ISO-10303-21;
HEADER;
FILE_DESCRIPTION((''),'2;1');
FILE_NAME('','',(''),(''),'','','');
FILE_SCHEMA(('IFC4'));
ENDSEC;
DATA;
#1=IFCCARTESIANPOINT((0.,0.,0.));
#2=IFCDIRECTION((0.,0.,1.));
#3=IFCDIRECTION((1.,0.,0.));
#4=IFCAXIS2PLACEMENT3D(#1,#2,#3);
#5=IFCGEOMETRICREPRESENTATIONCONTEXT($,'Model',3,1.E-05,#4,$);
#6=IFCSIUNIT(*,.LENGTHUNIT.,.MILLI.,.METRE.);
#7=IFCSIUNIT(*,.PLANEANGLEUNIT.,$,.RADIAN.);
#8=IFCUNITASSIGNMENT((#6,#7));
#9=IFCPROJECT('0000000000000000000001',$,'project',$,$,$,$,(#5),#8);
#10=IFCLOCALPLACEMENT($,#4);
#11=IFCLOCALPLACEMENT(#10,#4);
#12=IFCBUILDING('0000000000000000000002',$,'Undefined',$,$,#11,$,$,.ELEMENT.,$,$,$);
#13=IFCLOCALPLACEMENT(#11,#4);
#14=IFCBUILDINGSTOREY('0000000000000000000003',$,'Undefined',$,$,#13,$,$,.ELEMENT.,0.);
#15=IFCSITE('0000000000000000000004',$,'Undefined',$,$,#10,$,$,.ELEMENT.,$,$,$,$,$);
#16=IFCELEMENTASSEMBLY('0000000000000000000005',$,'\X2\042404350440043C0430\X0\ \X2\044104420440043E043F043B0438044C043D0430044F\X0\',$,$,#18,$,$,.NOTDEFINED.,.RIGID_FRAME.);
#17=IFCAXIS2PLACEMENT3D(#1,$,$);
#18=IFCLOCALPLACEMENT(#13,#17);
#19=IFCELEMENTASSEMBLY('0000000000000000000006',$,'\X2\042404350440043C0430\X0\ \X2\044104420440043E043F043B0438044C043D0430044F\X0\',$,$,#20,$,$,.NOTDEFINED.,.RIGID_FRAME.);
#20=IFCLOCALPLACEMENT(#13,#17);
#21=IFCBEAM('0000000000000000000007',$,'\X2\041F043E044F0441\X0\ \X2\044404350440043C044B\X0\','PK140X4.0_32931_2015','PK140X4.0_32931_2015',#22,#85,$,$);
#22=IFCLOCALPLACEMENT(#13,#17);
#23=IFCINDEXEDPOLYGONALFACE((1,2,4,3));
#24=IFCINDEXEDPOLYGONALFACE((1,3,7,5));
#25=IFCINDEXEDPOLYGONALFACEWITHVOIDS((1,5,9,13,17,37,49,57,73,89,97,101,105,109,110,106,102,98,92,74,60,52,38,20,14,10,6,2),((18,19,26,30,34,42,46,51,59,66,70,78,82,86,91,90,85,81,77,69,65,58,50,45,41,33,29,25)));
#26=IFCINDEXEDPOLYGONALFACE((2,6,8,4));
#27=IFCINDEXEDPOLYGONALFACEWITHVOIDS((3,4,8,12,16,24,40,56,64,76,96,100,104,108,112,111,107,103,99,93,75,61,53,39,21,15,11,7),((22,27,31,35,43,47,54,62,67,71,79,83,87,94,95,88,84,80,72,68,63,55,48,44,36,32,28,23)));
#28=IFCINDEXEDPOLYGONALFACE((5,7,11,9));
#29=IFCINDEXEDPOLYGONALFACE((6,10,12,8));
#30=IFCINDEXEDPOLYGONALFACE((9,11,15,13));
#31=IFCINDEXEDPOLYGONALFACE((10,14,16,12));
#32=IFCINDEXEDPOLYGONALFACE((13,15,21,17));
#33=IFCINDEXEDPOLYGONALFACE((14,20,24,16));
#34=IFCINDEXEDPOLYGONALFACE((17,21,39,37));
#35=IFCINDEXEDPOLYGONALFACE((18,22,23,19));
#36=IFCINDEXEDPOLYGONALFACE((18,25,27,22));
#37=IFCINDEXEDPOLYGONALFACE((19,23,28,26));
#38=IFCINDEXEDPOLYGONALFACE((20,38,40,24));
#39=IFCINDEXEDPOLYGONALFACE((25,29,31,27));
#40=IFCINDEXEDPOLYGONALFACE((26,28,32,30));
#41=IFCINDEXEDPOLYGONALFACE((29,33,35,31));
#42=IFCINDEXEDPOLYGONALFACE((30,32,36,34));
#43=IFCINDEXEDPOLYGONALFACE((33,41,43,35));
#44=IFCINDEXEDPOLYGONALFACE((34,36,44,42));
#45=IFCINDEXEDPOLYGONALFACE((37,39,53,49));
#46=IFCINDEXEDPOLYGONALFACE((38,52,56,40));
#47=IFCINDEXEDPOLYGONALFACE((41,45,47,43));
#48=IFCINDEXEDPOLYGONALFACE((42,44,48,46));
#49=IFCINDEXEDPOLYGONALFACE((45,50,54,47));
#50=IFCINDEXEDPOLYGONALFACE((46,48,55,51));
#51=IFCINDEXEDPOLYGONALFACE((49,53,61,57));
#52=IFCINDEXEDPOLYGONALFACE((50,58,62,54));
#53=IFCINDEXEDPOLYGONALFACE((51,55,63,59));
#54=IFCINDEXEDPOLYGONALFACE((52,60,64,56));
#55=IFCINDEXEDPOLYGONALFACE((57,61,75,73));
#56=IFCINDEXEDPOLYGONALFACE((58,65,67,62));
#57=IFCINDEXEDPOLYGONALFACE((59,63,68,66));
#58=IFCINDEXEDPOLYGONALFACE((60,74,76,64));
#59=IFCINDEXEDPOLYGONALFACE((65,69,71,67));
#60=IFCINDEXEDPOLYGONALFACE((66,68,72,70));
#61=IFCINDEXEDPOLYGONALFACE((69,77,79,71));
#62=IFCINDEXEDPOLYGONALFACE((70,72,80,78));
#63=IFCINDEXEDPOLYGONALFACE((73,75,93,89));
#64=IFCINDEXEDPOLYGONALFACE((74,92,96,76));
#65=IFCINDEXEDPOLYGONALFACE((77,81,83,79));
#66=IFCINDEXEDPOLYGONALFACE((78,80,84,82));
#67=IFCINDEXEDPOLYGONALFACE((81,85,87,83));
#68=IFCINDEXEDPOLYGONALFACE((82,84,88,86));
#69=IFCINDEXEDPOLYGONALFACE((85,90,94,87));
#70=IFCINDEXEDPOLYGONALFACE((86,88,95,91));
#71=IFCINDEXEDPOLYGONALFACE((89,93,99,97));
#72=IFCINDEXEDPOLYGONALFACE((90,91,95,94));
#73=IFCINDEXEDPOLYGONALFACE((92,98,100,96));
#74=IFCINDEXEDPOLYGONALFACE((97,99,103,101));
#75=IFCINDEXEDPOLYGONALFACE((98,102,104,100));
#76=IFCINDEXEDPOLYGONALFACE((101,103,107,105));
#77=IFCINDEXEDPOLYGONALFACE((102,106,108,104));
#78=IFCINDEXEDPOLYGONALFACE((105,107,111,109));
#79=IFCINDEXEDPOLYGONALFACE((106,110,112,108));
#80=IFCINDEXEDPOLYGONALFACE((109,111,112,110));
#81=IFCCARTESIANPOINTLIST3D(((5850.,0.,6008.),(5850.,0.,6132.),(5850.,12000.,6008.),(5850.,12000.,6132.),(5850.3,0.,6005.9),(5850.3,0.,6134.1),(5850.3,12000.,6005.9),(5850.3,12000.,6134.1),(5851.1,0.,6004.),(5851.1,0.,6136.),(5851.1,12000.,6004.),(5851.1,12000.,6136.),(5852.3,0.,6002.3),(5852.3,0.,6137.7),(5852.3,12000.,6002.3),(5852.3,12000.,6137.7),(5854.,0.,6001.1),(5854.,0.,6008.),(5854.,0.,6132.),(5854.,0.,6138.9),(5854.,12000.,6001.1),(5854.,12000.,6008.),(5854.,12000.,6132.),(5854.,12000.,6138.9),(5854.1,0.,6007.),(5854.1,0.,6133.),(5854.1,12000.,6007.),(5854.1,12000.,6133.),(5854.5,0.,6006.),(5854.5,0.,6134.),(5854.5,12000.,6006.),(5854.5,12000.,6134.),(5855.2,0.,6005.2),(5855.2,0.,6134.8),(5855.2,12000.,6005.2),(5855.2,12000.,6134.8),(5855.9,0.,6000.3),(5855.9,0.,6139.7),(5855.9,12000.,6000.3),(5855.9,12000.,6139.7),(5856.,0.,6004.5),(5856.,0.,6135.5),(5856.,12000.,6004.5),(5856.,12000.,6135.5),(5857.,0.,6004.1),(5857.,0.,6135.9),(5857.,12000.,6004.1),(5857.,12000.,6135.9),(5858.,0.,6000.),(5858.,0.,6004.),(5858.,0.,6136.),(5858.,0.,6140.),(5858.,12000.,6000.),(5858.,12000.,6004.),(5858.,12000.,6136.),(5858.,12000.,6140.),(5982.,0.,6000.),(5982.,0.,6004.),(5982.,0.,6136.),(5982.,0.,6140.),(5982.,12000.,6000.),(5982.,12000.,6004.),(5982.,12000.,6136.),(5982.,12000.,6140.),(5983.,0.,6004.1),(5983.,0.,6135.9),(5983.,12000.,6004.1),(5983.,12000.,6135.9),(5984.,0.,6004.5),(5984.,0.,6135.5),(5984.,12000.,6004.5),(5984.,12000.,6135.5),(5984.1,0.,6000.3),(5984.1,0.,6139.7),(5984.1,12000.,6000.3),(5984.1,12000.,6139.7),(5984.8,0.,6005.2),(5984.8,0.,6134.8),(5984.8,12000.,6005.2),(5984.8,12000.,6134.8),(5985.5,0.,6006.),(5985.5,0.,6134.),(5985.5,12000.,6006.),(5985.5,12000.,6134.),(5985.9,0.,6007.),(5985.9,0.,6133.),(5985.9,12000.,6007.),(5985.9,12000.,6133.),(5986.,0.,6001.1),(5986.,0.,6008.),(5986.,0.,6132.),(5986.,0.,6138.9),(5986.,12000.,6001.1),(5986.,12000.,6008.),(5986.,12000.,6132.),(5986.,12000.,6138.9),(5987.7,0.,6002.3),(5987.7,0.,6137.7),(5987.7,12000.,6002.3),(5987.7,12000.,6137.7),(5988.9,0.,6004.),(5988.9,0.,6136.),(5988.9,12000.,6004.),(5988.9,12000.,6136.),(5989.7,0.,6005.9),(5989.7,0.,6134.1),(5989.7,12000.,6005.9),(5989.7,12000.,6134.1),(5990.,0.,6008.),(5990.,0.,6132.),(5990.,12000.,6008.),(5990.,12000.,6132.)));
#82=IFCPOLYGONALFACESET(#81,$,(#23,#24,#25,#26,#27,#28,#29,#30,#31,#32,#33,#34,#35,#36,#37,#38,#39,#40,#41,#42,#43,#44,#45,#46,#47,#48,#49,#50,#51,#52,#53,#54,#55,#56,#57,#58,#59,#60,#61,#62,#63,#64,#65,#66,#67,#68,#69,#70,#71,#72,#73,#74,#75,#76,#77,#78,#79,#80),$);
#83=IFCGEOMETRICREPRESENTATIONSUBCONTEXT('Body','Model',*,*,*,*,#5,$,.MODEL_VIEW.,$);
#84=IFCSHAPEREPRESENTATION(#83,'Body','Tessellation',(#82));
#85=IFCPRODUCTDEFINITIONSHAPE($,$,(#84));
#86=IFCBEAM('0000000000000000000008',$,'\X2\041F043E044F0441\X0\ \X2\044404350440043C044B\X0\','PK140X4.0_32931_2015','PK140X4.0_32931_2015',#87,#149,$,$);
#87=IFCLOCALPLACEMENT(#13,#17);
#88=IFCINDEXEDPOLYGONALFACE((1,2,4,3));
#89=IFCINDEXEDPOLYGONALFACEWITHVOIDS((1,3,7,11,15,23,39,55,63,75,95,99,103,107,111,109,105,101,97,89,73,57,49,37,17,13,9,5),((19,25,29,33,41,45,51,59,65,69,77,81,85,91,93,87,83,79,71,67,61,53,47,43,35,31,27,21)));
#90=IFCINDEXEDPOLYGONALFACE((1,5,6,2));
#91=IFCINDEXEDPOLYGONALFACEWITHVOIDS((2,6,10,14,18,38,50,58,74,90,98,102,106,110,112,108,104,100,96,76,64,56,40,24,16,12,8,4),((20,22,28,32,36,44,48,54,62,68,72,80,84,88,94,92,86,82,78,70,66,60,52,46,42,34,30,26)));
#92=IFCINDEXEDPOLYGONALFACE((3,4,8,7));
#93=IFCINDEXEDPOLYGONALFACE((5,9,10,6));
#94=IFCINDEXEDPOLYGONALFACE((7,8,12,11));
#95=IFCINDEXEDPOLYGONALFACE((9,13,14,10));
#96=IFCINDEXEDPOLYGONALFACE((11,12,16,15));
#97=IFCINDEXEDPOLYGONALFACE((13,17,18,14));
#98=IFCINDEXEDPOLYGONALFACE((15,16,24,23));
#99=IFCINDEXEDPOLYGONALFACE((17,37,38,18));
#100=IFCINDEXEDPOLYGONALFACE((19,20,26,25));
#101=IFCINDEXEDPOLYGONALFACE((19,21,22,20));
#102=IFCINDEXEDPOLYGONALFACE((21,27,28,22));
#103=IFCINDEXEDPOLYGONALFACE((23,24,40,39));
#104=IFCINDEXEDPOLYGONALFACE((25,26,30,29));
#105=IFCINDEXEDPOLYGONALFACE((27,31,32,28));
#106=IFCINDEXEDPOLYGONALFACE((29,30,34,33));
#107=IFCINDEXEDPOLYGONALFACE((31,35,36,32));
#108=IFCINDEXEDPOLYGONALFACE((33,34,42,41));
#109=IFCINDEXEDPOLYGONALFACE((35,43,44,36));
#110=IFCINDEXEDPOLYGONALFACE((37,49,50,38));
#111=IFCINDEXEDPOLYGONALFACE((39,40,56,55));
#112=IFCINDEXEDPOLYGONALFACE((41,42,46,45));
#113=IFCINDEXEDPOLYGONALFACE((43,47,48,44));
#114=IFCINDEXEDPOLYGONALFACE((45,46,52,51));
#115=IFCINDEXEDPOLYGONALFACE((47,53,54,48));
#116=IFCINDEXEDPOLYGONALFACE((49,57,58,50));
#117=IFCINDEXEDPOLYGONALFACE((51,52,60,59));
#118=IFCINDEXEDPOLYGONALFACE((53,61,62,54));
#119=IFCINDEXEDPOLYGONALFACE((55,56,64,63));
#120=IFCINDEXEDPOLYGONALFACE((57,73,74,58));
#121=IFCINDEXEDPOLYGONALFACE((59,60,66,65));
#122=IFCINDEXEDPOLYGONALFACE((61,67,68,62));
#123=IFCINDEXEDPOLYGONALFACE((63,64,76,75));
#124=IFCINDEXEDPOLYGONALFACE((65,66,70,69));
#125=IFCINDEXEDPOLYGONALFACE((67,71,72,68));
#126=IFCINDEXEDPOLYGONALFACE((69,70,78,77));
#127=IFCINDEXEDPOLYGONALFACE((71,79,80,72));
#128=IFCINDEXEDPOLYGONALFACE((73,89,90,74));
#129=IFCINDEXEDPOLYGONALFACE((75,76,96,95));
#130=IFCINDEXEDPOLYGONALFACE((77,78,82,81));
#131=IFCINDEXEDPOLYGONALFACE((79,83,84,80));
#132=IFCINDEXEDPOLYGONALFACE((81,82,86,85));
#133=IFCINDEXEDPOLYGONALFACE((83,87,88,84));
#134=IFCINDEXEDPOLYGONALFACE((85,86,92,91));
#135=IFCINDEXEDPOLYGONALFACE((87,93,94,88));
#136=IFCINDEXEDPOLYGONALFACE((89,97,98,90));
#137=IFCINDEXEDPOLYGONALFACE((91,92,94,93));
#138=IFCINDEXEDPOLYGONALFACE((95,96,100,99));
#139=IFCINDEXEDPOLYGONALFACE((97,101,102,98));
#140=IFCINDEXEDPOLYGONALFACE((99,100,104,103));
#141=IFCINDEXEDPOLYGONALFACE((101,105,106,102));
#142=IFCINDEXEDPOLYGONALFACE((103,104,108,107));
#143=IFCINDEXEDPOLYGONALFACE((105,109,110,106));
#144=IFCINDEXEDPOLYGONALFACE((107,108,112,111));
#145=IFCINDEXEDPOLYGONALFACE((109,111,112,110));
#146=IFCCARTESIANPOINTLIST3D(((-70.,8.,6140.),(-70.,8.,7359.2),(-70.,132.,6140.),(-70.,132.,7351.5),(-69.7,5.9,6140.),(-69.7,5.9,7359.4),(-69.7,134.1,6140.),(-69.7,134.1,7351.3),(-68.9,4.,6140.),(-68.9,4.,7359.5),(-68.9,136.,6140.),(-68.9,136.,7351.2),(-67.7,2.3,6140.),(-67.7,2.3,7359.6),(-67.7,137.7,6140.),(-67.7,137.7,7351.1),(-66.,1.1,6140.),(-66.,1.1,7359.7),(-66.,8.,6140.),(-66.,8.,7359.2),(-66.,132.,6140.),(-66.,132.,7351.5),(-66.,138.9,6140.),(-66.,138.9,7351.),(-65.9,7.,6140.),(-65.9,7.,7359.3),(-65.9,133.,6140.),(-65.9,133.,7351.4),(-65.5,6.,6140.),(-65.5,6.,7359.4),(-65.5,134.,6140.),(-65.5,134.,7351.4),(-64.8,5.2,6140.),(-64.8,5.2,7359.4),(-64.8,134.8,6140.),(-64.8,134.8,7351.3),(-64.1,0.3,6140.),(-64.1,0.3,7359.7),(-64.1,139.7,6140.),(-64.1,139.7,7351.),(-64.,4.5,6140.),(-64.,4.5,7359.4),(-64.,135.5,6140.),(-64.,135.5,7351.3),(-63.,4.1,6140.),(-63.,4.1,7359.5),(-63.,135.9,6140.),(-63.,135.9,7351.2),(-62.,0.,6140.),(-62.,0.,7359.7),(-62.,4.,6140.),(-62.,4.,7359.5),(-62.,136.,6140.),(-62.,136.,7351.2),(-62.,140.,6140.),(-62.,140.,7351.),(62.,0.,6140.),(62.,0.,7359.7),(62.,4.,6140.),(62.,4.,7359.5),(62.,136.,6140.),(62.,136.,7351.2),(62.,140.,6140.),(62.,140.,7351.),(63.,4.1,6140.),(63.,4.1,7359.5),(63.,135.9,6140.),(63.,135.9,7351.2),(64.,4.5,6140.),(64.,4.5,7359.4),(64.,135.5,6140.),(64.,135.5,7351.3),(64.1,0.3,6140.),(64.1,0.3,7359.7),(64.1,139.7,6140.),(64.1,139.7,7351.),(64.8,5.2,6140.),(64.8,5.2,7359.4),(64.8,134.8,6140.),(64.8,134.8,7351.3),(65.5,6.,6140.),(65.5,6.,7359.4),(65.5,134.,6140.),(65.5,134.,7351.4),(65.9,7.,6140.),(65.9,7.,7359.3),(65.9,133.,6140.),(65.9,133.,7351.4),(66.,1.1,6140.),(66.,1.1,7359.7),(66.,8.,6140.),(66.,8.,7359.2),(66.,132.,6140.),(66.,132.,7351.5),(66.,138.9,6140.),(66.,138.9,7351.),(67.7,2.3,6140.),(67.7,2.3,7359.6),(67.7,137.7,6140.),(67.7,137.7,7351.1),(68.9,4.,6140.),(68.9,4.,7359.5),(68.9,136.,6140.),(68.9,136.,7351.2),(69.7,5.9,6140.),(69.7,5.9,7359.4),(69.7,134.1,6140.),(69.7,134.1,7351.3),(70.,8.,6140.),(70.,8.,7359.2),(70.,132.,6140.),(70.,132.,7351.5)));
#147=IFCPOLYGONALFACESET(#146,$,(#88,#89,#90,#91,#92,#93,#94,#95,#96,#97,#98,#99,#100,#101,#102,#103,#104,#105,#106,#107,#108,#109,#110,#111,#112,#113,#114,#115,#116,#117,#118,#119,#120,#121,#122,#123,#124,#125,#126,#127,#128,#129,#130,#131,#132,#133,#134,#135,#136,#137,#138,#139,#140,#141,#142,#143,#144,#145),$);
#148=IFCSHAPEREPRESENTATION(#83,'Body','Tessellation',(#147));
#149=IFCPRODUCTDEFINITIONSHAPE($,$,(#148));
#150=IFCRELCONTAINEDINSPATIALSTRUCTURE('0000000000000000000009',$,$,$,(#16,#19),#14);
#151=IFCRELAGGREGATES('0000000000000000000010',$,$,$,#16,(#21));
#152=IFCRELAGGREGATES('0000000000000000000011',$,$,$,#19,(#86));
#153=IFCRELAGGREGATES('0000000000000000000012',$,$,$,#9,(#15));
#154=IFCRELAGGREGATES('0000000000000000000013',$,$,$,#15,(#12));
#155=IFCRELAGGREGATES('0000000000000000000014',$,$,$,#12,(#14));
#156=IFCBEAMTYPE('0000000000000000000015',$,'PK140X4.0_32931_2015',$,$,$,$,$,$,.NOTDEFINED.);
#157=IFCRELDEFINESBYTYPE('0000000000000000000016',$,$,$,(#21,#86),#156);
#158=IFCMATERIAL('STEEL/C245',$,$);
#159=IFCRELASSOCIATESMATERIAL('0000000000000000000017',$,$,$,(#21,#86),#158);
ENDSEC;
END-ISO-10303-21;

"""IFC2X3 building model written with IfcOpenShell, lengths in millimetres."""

from ifc_helpers import new_model, si_unit, frame, origin_with_axes, origin_2d_with_axis, place, context, subcontext, project, spatial, hollow_rectangle, extrude, clip, halfspace, material, type_object, element, aggregate, save


model = new_model("IFC2X3")

# Units and contexts
model_context = context("Model", 3, precision=1e-05, world=origin_with_axes())
body_context = subcontext(model_context, "Body", "Model", "MODEL_VIEW")
ifc_project = project(units=[si_unit("LENGTHUNIT", "METRE", prefix="MILLI"), si_unit("PLANEANGLEUNIT", "RADIAN")], contexts=[model_context])

# Site, building, storey
site_placement = place(None, origin_with_axes())
site = spatial("IfcSite", under=ifc_project, at=site_placement, Name="Undefined", CompositionType="ELEMENT")
building_placement = place(site_placement, origin_with_axes())
building = spatial("IfcBuilding", under=site, at=building_placement, Name="Undefined", CompositionType="ELEMENT")
storey_placement = place(building_placement, origin_with_axes())
storey = spatial("IfcBuildingStorey", under=building, at=storey_placement, Name="Undefined", CompositionType="ELEMENT", Elevation=0.0)

# Shared definitions
ifc_material = material(Name="STEEL/C245")

# Element assemblies
assembly_1_placement = place(storey_placement, origin_with_axes())
assembly_1 = element("IfcElementAssembly", 1, at=assembly_1_placement, inside=storey, Name="Ферма строплиьная", AssemblyPlace="NOTDEFINED", PredefinedType="RIGID_FRAME")
assembly_2_placement = place(storey_placement, origin_with_axes())
assembly_2 = element("IfcElementAssembly", 2, at=assembly_2_placement, inside=storey, Name="Ферма строплиьная", AssemblyPlace="NOTDEFINED", PredefinedType="RIGID_FRAME")

# Beams
beam_type_1 = type_object("IfcBeamType", Name="PK140X4.0_32931_2015", PredefinedType="NOTDEFINED")
beam_1_placement = place(assembly_1_placement, frame((5920.0, 0.0, 6070.0), z_axis=(0.0, 0.0, 1.0), x_axis=(0.0, 1.0, 0.0)))
beam_1 = element("IfcBeam", 3, at=beam_1_placement, type_object=beam_type_1, material=ifc_material, Name="Пояс фермы", Description="PK140X4.0_32931_2015", ObjectType="PK140X4.0_32931_2015", context=body_context, shape_type="SweptSolid", body=[
    extrude(hollow_rectangle(XDim=140.0, YDim=140.0, WallThickness=4.0, InnerFilletRadius=4.0, OuterFilletRadius=8.0, at=origin_2d_with_axis()), frame((12000.0, 0.0, 0.0), z_axis=(-1.0, 0.0, 0.0), x_axis=(0.0, -1.0, 0.0)), (0.0, 0.0, 1.0), 12000.0),
])
aggregate(assembly_1, [beam_1])
beam_2_placement = place(assembly_2_placement, frame((0.0, 70.0, 7359.7), z_axis=(1.0, 0.0, 0.0), x_axis=(0.0, 0.0, -1.0)))
beam_2 = element("IfcBeam", 4, at=beam_2_placement, type_object=beam_type_1, material=ifc_material, Name="Пояс фермы", Description="PK140X4.0_32931_2015", ObjectType="PK140X4.0_32931_2015", context=body_context, shape_type="Clipping", body=[
    clip(extrude(hollow_rectangle(XDim=140.0, YDim=140.0, WallThickness=4.0, InnerFilletRadius=4.0, OuterFilletRadius=8.0, at=origin_2d_with_axis()), frame((1219.7, 0.0, 0.0), z_axis=(-1.0, 0.0, 0.0), x_axis=(0.0, -1.0, 0.0)), (0.0, 0.0, 1.0), 1219.8), halfspace(frame((10.5, 98.4, 0.0), z_axis=(0.998053, -0.062378, 0.0), x_axis=(0.0, 0.0, 1.0)), True)),
])
aggregate(assembly_2, [beam_2])

save(model, "model.ifc")
